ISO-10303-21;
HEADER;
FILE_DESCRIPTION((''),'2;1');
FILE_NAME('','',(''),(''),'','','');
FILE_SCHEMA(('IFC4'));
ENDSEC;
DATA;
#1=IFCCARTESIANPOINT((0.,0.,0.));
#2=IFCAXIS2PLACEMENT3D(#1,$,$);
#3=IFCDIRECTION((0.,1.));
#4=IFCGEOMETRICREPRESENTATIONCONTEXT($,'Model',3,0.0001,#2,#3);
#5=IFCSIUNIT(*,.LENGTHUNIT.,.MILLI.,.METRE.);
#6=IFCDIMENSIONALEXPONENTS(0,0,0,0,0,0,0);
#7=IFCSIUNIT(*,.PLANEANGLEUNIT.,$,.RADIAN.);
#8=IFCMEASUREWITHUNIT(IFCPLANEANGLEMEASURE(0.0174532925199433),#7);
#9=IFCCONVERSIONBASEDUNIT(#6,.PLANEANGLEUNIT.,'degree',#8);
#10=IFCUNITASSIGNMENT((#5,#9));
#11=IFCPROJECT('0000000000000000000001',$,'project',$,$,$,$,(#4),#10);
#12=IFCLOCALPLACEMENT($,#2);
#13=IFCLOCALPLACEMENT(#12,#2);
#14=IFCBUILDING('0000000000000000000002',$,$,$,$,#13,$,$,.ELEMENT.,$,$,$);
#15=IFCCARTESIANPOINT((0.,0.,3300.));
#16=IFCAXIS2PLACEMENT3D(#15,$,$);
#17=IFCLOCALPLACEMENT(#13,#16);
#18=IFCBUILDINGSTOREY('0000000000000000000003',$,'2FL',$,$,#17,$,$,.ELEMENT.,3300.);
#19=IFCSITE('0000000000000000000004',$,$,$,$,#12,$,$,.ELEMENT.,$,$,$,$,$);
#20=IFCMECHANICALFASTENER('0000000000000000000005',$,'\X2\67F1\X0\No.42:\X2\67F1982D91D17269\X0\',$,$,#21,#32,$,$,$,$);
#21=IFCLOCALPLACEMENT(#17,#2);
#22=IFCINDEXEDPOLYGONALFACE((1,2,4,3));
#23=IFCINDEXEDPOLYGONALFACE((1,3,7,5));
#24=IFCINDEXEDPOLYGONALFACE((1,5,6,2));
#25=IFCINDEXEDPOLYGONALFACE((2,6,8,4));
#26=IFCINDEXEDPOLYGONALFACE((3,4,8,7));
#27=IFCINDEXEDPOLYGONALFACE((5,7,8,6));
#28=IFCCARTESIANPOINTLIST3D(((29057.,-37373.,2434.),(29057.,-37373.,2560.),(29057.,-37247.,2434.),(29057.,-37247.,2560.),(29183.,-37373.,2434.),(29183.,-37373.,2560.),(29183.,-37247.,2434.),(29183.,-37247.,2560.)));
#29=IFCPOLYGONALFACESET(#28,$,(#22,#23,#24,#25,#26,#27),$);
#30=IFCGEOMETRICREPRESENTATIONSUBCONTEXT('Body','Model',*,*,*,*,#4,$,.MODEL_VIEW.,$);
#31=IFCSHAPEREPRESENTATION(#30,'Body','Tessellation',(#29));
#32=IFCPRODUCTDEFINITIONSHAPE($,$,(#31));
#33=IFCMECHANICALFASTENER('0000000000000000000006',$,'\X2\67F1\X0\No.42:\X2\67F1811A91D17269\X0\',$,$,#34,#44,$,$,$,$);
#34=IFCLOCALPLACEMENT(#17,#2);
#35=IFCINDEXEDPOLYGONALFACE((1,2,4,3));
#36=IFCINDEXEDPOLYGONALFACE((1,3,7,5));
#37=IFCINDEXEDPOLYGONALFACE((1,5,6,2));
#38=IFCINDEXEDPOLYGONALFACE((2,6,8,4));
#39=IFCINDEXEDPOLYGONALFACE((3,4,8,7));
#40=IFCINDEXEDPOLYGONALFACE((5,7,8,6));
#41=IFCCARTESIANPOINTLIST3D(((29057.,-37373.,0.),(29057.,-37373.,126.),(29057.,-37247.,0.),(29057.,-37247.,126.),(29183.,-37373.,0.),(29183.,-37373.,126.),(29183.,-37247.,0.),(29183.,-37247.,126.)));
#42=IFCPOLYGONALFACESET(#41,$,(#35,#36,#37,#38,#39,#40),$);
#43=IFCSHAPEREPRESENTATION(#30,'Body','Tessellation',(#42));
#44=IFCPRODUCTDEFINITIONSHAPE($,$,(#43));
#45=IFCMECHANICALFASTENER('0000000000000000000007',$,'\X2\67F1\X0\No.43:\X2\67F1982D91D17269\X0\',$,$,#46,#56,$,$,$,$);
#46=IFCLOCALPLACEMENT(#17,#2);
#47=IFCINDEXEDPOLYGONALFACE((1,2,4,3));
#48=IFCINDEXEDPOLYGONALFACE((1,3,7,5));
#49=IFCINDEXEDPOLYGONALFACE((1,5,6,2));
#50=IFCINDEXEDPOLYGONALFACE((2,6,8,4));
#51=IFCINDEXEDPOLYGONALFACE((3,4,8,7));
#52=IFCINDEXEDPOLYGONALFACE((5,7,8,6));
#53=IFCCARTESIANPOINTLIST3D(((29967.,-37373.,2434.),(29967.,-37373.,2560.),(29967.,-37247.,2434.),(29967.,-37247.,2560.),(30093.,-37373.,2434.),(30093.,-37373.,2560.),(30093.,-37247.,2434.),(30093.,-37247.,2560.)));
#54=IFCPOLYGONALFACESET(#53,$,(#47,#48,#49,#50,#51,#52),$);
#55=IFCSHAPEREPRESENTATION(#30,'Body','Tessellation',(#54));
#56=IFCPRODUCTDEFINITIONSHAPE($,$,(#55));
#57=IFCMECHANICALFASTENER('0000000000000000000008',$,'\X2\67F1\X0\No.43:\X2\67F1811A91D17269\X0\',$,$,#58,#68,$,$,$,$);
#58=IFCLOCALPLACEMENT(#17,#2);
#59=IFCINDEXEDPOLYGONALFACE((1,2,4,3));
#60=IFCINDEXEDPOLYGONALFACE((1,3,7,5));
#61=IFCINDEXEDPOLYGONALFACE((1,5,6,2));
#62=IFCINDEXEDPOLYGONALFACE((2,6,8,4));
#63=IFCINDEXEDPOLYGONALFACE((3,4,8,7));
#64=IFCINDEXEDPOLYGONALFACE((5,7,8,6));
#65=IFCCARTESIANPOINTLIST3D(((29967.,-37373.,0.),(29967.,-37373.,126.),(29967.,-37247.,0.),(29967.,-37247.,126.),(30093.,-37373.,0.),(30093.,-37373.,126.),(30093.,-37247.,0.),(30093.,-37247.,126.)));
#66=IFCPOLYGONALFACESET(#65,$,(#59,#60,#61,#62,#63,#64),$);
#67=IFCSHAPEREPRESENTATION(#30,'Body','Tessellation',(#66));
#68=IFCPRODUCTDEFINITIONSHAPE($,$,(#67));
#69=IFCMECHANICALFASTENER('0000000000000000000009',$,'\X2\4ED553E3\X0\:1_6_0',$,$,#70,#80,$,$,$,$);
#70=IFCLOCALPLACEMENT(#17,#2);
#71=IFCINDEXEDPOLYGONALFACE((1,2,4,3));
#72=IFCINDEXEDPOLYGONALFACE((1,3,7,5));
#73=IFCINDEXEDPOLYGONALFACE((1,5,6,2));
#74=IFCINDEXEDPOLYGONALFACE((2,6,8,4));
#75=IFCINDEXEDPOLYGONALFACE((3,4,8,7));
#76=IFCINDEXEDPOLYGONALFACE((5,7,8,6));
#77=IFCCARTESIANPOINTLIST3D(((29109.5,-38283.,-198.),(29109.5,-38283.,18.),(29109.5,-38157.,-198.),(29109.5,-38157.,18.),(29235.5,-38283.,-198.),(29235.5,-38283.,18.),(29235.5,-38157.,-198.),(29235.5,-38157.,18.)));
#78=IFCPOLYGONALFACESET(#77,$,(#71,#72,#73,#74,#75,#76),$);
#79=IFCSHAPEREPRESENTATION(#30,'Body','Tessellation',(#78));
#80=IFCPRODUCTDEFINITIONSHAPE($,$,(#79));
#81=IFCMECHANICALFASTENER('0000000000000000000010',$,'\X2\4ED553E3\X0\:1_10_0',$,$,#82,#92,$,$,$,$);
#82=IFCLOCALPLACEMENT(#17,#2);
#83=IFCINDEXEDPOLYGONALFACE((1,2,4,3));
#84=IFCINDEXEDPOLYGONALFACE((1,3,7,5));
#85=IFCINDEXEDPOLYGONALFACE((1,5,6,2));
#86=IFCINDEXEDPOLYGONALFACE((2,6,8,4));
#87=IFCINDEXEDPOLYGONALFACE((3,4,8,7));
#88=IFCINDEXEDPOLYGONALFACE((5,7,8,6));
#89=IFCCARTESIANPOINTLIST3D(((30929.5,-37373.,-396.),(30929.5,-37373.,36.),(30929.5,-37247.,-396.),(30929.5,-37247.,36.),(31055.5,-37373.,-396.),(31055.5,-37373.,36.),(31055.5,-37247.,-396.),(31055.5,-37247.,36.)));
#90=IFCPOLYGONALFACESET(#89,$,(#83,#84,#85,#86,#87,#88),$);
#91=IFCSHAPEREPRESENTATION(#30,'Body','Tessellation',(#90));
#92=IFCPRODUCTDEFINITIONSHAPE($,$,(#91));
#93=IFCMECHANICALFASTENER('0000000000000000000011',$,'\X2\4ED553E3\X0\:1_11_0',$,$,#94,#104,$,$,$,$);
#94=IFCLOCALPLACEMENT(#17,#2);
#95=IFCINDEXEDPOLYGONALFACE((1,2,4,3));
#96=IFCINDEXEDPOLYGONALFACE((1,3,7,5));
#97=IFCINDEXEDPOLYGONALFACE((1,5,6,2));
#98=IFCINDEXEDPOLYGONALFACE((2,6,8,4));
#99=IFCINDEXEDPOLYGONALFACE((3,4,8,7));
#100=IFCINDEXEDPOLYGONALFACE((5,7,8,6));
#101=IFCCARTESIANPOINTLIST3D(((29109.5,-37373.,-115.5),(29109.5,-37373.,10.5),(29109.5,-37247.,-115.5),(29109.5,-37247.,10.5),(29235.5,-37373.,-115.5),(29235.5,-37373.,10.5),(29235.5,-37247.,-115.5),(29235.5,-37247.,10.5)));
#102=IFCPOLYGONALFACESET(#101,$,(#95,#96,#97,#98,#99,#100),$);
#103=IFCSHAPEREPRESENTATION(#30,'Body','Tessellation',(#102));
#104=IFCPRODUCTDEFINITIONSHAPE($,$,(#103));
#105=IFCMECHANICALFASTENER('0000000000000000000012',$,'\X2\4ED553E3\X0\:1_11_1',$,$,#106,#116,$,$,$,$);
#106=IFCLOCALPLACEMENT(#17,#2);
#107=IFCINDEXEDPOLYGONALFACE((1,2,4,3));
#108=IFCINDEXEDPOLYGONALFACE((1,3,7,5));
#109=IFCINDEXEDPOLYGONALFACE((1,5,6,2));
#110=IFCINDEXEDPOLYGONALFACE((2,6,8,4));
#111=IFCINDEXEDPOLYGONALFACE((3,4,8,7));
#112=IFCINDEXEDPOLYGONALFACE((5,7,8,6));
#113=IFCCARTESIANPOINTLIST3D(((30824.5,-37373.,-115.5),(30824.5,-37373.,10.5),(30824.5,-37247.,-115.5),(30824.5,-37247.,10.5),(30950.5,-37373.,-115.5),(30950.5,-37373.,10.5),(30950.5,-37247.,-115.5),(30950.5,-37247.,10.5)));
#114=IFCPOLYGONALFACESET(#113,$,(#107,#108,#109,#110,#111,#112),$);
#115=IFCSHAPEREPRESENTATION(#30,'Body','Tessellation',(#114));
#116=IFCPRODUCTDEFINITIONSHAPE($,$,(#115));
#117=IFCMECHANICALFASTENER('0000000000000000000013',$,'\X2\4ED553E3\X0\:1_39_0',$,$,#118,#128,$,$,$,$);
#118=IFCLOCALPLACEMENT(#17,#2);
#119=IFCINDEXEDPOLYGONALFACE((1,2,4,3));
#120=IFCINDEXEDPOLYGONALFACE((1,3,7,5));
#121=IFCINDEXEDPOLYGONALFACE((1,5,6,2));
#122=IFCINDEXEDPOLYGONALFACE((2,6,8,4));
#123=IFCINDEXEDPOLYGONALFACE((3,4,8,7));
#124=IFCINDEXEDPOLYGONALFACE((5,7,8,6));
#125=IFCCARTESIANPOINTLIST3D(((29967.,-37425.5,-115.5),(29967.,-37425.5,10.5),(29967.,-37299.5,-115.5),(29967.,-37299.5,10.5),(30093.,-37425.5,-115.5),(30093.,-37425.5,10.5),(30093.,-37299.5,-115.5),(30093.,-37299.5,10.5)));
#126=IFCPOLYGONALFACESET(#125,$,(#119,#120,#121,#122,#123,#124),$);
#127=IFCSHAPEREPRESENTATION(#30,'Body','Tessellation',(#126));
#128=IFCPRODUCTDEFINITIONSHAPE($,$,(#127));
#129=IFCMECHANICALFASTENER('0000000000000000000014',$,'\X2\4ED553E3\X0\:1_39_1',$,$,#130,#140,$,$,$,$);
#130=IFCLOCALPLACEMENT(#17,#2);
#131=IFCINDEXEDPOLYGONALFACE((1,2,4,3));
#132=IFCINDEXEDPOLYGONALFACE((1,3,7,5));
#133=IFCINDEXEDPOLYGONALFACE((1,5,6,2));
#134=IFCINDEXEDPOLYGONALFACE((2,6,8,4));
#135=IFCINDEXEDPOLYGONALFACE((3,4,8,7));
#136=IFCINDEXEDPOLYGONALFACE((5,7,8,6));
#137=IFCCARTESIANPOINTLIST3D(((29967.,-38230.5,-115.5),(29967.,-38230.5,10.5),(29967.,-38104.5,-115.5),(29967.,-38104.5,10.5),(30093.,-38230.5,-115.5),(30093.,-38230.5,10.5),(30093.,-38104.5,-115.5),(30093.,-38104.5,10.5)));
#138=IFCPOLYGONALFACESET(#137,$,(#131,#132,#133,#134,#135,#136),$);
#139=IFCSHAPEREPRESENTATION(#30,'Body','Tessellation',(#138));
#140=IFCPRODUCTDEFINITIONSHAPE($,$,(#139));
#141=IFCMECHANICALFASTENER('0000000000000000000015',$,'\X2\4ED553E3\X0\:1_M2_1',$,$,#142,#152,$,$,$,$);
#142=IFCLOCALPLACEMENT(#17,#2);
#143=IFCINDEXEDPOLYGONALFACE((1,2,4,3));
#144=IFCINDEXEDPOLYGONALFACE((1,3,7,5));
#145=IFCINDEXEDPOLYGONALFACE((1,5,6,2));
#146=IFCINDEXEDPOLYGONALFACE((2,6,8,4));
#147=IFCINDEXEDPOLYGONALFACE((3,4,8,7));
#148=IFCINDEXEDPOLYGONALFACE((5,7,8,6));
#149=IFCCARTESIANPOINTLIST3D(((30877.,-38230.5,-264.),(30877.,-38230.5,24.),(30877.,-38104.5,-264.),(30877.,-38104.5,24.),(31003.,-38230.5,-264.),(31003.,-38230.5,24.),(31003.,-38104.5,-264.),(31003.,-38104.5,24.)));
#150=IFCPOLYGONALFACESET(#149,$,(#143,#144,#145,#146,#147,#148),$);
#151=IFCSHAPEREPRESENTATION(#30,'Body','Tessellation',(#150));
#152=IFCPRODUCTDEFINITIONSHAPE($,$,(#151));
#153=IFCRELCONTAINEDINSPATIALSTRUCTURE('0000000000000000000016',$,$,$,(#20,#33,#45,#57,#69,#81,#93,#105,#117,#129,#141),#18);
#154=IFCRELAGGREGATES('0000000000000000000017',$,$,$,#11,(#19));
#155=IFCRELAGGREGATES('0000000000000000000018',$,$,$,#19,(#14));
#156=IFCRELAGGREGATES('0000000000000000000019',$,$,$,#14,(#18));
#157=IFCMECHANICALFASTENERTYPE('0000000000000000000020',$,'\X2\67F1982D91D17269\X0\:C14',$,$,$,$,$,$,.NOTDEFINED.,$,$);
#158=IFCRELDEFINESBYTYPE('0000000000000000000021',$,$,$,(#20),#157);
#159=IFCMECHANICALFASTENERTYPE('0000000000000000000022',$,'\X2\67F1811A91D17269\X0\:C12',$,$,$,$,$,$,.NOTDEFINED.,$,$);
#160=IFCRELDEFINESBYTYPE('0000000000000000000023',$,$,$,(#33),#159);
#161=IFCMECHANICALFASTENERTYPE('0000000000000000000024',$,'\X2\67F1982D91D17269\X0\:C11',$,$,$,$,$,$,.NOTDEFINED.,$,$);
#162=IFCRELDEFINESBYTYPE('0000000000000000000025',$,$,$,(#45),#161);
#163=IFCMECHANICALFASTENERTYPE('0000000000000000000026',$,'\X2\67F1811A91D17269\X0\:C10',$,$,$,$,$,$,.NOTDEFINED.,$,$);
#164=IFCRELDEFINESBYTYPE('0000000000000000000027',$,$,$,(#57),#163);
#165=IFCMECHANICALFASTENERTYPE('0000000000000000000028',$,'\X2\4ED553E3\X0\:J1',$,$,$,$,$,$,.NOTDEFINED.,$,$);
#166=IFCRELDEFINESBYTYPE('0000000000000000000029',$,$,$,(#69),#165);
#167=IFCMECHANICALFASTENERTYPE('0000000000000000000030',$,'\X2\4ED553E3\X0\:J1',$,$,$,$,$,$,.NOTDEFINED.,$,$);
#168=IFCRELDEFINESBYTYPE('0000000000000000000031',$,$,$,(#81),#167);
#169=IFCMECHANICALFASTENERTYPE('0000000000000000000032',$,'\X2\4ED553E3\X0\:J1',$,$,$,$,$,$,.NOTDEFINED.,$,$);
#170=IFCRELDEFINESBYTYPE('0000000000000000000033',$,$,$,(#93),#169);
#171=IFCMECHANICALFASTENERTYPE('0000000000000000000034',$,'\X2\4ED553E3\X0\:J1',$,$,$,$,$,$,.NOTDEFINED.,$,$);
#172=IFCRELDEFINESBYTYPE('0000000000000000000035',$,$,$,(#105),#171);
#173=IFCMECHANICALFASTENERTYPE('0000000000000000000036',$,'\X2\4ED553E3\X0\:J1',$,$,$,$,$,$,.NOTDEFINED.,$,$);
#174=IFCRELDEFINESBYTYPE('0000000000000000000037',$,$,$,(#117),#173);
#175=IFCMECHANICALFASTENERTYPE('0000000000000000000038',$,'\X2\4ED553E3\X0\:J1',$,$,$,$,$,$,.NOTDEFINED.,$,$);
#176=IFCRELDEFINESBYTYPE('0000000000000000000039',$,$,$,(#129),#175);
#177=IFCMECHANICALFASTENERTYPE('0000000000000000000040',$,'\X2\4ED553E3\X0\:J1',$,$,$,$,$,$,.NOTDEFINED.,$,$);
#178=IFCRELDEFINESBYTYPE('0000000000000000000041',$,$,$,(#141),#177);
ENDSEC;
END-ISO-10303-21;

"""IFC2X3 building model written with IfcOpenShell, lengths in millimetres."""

from ifc_helpers import new_model, entity, si_unit, converted_unit, direction, frame, origin, origin_with_axes, origin_2d, place, context, subcontext, project, spatial, rectangle, extrude, type_object, element, save


model = new_model("IFC2X3")

# Units and contexts
model_context = context("Model", 3, precision=0.0001, world=origin(), true_north=direction((0.0, 1.0)))
body_context = subcontext(model_context, "Body", "Model", "MODEL_VIEW")
ifc_project = project(units=[si_unit("LENGTHUNIT", "METRE", prefix="MILLI"), converted_unit("PLANEANGLEUNIT", "degree", entity("IfcPlaneAngleMeasure", 0.0174532925199433), si_unit("PLANEANGLEUNIT", "RADIAN"), dimensions=[0, 0, 0, 0, 0, 0, 0])], contexts=[model_context])

# Site, building, storey
site_placement = place(None, origin())
site = spatial("IfcSite", under=ifc_project, at=site_placement, CompositionType="ELEMENT")
building_placement = place(site_placement, origin())
building = spatial("IfcBuilding", under=site, at=building_placement, CompositionType="ELEMENT")
storey_placement = place(building_placement, frame((0.0, 0.0, 3300.0)))
storey = spatial("IfcBuildingStorey", under=building, at=storey_placement, Name="2FL", CompositionType="ELEMENT", Elevation=3300.0)

# Mechanical fasteners
mechanical_fastener_type_1 = type_object("IfcMechanicalFastenerType", Name="柱頭金物:C14")
mechanical_fastener_1_placement = place(storey_placement, frame((29120.0, -37310.0, 2434.0)))
element("IfcMechanicalFastener", 1, at=mechanical_fastener_1_placement, inside=storey, type_object=mechanical_fastener_type_1, Name="柱No.42:柱頭金物", context=body_context, shape_type="SweptSolid", body=[
    extrude(rectangle(XDim=126.0, YDim=126.0, at=origin_2d()), origin_with_axes(), (0.0, 0.0, 1.0), 126.0),
])
mechanical_fastener_type_2 = type_object("IfcMechanicalFastenerType", Name="柱脚金物:C12")
mechanical_fastener_2_placement = place(storey_placement, frame((29120.0, -37310.0, 0.0)))
element("IfcMechanicalFastener", 2, at=mechanical_fastener_2_placement, inside=storey, type_object=mechanical_fastener_type_2, Name="柱No.42:柱脚金物", context=body_context, shape_type="SweptSolid", body=[
    extrude(rectangle(XDim=126.0, YDim=126.0, at=origin_2d()), origin_with_axes(), (0.0, 0.0, 1.0), 126.0),
])
mechanical_fastener_type_3 = type_object("IfcMechanicalFastenerType", Name="柱頭金物:C11")
mechanical_fastener_3_placement = place(storey_placement, frame((30030.0, -37310.0, 2434.0)))
element("IfcMechanicalFastener", 3, at=mechanical_fastener_3_placement, inside=storey, type_object=mechanical_fastener_type_3, Name="柱No.43:柱頭金物", context=body_context, shape_type="SweptSolid", body=[
    extrude(rectangle(XDim=126.0, YDim=126.0, at=origin_2d()), origin_with_axes(), (0.0, 0.0, 1.0), 126.0),
])
mechanical_fastener_type_4 = type_object("IfcMechanicalFastenerType", Name="柱脚金物:C10")
mechanical_fastener_4_placement = place(storey_placement, frame((30030.0, -37310.0, 0.0)))
element("IfcMechanicalFastener", 4, at=mechanical_fastener_4_placement, inside=storey, type_object=mechanical_fastener_type_4, Name="柱No.43:柱脚金物", context=body_context, shape_type="SweptSolid", body=[
    extrude(rectangle(XDim=126.0, YDim=126.0, at=origin_2d()), origin_with_axes(), (0.0, 0.0, 1.0), 126.0),
])
mechanical_fastener_type_5 = type_object("IfcMechanicalFastenerType", Name="仕口:J1")
mechanical_fastener_5_placement = place(storey_placement, frame((29172.5, -38220.0, -198.0)))
element("IfcMechanicalFastener", 5, at=mechanical_fastener_5_placement, inside=storey, type_object=mechanical_fastener_type_5, Name="仕口:1_6_0", context=body_context, shape_type="SweptSolid", body=[
    extrude(rectangle(XDim=126.0, YDim=126.0, at=origin_2d()), origin_with_axes(), (0.0, 0.0, 1.0), 216.0),
])
mechanical_fastener_type_6 = type_object("IfcMechanicalFastenerType", Name="仕口:J1")
mechanical_fastener_6_placement = place(storey_placement, frame((30992.5, -37310.0, -396.0)))
element("IfcMechanicalFastener", 6, at=mechanical_fastener_6_placement, inside=storey, type_object=mechanical_fastener_type_6, Name="仕口:1_10_0", context=body_context, shape_type="SweptSolid", body=[
    extrude(rectangle(XDim=126.0, YDim=126.0, at=origin_2d()), origin_with_axes(), (0.0, 0.0, 1.0), 432.0),
])
mechanical_fastener_type_7 = type_object("IfcMechanicalFastenerType", Name="仕口:J1")
mechanical_fastener_7_placement = place(storey_placement, frame((29172.5, -37310.0, -115.5)))
element("IfcMechanicalFastener", 7, at=mechanical_fastener_7_placement, inside=storey, type_object=mechanical_fastener_type_7, Name="仕口:1_11_0", context=body_context, shape_type="SweptSolid", body=[
    extrude(rectangle(XDim=126.0, YDim=126.0, at=origin_2d()), origin_with_axes(), (0.0, 0.0, 1.0), 126.0),
])
mechanical_fastener_type_8 = type_object("IfcMechanicalFastenerType", Name="仕口:J1")
mechanical_fastener_8_placement = place(storey_placement, frame((30887.5, -37310.0, -115.5)))
element("IfcMechanicalFastener", 8, at=mechanical_fastener_8_placement, inside=storey, type_object=mechanical_fastener_type_8, Name="仕口:1_11_1", context=body_context, shape_type="SweptSolid", body=[
    extrude(rectangle(XDim=126.0, YDim=126.0, at=origin_2d()), origin_with_axes(), (0.0, 0.0, 1.0), 126.0),
])
mechanical_fastener_type_9 = type_object("IfcMechanicalFastenerType", Name="仕口:J1")
mechanical_fastener_9_placement = place(storey_placement, frame((30030.0, -37362.5, -115.5)))
element("IfcMechanicalFastener", 9, at=mechanical_fastener_9_placement, inside=storey, type_object=mechanical_fastener_type_9, Name="仕口:1_39_0", context=body_context, shape_type="SweptSolid", body=[
    extrude(rectangle(XDim=126.0, YDim=126.0, at=origin_2d()), origin_with_axes(), (0.0, 0.0, 1.0), 126.0),
])
mechanical_fastener_type_10 = type_object("IfcMechanicalFastenerType", Name="仕口:J1")
mechanical_fastener_10_placement = place(storey_placement, frame((30030.0, -38167.5, -115.5)))
element("IfcMechanicalFastener", 10, at=mechanical_fastener_10_placement, inside=storey, type_object=mechanical_fastener_type_10, Name="仕口:1_39_1", context=body_context, shape_type="SweptSolid", body=[
    extrude(rectangle(XDim=126.0, YDim=126.0, at=origin_2d()), origin_with_axes(), (0.0, 0.0, 1.0), 126.0),
])
mechanical_fastener_type_11 = type_object("IfcMechanicalFastenerType", Name="仕口:J1")
mechanical_fastener_11_placement = place(storey_placement, frame((30940.0, -38167.5, -264.0)))
element("IfcMechanicalFastener", 11, at=mechanical_fastener_11_placement, inside=storey, type_object=mechanical_fastener_type_11, Name="仕口:1_M2_1", context=body_context, shape_type="SweptSolid", body=[
    extrude(rectangle(XDim=126.0, YDim=126.0, at=origin_2d()), origin_with_axes(), (0.0, 0.0, 1.0), 288.0),
])

save(model, "model.ifc")
